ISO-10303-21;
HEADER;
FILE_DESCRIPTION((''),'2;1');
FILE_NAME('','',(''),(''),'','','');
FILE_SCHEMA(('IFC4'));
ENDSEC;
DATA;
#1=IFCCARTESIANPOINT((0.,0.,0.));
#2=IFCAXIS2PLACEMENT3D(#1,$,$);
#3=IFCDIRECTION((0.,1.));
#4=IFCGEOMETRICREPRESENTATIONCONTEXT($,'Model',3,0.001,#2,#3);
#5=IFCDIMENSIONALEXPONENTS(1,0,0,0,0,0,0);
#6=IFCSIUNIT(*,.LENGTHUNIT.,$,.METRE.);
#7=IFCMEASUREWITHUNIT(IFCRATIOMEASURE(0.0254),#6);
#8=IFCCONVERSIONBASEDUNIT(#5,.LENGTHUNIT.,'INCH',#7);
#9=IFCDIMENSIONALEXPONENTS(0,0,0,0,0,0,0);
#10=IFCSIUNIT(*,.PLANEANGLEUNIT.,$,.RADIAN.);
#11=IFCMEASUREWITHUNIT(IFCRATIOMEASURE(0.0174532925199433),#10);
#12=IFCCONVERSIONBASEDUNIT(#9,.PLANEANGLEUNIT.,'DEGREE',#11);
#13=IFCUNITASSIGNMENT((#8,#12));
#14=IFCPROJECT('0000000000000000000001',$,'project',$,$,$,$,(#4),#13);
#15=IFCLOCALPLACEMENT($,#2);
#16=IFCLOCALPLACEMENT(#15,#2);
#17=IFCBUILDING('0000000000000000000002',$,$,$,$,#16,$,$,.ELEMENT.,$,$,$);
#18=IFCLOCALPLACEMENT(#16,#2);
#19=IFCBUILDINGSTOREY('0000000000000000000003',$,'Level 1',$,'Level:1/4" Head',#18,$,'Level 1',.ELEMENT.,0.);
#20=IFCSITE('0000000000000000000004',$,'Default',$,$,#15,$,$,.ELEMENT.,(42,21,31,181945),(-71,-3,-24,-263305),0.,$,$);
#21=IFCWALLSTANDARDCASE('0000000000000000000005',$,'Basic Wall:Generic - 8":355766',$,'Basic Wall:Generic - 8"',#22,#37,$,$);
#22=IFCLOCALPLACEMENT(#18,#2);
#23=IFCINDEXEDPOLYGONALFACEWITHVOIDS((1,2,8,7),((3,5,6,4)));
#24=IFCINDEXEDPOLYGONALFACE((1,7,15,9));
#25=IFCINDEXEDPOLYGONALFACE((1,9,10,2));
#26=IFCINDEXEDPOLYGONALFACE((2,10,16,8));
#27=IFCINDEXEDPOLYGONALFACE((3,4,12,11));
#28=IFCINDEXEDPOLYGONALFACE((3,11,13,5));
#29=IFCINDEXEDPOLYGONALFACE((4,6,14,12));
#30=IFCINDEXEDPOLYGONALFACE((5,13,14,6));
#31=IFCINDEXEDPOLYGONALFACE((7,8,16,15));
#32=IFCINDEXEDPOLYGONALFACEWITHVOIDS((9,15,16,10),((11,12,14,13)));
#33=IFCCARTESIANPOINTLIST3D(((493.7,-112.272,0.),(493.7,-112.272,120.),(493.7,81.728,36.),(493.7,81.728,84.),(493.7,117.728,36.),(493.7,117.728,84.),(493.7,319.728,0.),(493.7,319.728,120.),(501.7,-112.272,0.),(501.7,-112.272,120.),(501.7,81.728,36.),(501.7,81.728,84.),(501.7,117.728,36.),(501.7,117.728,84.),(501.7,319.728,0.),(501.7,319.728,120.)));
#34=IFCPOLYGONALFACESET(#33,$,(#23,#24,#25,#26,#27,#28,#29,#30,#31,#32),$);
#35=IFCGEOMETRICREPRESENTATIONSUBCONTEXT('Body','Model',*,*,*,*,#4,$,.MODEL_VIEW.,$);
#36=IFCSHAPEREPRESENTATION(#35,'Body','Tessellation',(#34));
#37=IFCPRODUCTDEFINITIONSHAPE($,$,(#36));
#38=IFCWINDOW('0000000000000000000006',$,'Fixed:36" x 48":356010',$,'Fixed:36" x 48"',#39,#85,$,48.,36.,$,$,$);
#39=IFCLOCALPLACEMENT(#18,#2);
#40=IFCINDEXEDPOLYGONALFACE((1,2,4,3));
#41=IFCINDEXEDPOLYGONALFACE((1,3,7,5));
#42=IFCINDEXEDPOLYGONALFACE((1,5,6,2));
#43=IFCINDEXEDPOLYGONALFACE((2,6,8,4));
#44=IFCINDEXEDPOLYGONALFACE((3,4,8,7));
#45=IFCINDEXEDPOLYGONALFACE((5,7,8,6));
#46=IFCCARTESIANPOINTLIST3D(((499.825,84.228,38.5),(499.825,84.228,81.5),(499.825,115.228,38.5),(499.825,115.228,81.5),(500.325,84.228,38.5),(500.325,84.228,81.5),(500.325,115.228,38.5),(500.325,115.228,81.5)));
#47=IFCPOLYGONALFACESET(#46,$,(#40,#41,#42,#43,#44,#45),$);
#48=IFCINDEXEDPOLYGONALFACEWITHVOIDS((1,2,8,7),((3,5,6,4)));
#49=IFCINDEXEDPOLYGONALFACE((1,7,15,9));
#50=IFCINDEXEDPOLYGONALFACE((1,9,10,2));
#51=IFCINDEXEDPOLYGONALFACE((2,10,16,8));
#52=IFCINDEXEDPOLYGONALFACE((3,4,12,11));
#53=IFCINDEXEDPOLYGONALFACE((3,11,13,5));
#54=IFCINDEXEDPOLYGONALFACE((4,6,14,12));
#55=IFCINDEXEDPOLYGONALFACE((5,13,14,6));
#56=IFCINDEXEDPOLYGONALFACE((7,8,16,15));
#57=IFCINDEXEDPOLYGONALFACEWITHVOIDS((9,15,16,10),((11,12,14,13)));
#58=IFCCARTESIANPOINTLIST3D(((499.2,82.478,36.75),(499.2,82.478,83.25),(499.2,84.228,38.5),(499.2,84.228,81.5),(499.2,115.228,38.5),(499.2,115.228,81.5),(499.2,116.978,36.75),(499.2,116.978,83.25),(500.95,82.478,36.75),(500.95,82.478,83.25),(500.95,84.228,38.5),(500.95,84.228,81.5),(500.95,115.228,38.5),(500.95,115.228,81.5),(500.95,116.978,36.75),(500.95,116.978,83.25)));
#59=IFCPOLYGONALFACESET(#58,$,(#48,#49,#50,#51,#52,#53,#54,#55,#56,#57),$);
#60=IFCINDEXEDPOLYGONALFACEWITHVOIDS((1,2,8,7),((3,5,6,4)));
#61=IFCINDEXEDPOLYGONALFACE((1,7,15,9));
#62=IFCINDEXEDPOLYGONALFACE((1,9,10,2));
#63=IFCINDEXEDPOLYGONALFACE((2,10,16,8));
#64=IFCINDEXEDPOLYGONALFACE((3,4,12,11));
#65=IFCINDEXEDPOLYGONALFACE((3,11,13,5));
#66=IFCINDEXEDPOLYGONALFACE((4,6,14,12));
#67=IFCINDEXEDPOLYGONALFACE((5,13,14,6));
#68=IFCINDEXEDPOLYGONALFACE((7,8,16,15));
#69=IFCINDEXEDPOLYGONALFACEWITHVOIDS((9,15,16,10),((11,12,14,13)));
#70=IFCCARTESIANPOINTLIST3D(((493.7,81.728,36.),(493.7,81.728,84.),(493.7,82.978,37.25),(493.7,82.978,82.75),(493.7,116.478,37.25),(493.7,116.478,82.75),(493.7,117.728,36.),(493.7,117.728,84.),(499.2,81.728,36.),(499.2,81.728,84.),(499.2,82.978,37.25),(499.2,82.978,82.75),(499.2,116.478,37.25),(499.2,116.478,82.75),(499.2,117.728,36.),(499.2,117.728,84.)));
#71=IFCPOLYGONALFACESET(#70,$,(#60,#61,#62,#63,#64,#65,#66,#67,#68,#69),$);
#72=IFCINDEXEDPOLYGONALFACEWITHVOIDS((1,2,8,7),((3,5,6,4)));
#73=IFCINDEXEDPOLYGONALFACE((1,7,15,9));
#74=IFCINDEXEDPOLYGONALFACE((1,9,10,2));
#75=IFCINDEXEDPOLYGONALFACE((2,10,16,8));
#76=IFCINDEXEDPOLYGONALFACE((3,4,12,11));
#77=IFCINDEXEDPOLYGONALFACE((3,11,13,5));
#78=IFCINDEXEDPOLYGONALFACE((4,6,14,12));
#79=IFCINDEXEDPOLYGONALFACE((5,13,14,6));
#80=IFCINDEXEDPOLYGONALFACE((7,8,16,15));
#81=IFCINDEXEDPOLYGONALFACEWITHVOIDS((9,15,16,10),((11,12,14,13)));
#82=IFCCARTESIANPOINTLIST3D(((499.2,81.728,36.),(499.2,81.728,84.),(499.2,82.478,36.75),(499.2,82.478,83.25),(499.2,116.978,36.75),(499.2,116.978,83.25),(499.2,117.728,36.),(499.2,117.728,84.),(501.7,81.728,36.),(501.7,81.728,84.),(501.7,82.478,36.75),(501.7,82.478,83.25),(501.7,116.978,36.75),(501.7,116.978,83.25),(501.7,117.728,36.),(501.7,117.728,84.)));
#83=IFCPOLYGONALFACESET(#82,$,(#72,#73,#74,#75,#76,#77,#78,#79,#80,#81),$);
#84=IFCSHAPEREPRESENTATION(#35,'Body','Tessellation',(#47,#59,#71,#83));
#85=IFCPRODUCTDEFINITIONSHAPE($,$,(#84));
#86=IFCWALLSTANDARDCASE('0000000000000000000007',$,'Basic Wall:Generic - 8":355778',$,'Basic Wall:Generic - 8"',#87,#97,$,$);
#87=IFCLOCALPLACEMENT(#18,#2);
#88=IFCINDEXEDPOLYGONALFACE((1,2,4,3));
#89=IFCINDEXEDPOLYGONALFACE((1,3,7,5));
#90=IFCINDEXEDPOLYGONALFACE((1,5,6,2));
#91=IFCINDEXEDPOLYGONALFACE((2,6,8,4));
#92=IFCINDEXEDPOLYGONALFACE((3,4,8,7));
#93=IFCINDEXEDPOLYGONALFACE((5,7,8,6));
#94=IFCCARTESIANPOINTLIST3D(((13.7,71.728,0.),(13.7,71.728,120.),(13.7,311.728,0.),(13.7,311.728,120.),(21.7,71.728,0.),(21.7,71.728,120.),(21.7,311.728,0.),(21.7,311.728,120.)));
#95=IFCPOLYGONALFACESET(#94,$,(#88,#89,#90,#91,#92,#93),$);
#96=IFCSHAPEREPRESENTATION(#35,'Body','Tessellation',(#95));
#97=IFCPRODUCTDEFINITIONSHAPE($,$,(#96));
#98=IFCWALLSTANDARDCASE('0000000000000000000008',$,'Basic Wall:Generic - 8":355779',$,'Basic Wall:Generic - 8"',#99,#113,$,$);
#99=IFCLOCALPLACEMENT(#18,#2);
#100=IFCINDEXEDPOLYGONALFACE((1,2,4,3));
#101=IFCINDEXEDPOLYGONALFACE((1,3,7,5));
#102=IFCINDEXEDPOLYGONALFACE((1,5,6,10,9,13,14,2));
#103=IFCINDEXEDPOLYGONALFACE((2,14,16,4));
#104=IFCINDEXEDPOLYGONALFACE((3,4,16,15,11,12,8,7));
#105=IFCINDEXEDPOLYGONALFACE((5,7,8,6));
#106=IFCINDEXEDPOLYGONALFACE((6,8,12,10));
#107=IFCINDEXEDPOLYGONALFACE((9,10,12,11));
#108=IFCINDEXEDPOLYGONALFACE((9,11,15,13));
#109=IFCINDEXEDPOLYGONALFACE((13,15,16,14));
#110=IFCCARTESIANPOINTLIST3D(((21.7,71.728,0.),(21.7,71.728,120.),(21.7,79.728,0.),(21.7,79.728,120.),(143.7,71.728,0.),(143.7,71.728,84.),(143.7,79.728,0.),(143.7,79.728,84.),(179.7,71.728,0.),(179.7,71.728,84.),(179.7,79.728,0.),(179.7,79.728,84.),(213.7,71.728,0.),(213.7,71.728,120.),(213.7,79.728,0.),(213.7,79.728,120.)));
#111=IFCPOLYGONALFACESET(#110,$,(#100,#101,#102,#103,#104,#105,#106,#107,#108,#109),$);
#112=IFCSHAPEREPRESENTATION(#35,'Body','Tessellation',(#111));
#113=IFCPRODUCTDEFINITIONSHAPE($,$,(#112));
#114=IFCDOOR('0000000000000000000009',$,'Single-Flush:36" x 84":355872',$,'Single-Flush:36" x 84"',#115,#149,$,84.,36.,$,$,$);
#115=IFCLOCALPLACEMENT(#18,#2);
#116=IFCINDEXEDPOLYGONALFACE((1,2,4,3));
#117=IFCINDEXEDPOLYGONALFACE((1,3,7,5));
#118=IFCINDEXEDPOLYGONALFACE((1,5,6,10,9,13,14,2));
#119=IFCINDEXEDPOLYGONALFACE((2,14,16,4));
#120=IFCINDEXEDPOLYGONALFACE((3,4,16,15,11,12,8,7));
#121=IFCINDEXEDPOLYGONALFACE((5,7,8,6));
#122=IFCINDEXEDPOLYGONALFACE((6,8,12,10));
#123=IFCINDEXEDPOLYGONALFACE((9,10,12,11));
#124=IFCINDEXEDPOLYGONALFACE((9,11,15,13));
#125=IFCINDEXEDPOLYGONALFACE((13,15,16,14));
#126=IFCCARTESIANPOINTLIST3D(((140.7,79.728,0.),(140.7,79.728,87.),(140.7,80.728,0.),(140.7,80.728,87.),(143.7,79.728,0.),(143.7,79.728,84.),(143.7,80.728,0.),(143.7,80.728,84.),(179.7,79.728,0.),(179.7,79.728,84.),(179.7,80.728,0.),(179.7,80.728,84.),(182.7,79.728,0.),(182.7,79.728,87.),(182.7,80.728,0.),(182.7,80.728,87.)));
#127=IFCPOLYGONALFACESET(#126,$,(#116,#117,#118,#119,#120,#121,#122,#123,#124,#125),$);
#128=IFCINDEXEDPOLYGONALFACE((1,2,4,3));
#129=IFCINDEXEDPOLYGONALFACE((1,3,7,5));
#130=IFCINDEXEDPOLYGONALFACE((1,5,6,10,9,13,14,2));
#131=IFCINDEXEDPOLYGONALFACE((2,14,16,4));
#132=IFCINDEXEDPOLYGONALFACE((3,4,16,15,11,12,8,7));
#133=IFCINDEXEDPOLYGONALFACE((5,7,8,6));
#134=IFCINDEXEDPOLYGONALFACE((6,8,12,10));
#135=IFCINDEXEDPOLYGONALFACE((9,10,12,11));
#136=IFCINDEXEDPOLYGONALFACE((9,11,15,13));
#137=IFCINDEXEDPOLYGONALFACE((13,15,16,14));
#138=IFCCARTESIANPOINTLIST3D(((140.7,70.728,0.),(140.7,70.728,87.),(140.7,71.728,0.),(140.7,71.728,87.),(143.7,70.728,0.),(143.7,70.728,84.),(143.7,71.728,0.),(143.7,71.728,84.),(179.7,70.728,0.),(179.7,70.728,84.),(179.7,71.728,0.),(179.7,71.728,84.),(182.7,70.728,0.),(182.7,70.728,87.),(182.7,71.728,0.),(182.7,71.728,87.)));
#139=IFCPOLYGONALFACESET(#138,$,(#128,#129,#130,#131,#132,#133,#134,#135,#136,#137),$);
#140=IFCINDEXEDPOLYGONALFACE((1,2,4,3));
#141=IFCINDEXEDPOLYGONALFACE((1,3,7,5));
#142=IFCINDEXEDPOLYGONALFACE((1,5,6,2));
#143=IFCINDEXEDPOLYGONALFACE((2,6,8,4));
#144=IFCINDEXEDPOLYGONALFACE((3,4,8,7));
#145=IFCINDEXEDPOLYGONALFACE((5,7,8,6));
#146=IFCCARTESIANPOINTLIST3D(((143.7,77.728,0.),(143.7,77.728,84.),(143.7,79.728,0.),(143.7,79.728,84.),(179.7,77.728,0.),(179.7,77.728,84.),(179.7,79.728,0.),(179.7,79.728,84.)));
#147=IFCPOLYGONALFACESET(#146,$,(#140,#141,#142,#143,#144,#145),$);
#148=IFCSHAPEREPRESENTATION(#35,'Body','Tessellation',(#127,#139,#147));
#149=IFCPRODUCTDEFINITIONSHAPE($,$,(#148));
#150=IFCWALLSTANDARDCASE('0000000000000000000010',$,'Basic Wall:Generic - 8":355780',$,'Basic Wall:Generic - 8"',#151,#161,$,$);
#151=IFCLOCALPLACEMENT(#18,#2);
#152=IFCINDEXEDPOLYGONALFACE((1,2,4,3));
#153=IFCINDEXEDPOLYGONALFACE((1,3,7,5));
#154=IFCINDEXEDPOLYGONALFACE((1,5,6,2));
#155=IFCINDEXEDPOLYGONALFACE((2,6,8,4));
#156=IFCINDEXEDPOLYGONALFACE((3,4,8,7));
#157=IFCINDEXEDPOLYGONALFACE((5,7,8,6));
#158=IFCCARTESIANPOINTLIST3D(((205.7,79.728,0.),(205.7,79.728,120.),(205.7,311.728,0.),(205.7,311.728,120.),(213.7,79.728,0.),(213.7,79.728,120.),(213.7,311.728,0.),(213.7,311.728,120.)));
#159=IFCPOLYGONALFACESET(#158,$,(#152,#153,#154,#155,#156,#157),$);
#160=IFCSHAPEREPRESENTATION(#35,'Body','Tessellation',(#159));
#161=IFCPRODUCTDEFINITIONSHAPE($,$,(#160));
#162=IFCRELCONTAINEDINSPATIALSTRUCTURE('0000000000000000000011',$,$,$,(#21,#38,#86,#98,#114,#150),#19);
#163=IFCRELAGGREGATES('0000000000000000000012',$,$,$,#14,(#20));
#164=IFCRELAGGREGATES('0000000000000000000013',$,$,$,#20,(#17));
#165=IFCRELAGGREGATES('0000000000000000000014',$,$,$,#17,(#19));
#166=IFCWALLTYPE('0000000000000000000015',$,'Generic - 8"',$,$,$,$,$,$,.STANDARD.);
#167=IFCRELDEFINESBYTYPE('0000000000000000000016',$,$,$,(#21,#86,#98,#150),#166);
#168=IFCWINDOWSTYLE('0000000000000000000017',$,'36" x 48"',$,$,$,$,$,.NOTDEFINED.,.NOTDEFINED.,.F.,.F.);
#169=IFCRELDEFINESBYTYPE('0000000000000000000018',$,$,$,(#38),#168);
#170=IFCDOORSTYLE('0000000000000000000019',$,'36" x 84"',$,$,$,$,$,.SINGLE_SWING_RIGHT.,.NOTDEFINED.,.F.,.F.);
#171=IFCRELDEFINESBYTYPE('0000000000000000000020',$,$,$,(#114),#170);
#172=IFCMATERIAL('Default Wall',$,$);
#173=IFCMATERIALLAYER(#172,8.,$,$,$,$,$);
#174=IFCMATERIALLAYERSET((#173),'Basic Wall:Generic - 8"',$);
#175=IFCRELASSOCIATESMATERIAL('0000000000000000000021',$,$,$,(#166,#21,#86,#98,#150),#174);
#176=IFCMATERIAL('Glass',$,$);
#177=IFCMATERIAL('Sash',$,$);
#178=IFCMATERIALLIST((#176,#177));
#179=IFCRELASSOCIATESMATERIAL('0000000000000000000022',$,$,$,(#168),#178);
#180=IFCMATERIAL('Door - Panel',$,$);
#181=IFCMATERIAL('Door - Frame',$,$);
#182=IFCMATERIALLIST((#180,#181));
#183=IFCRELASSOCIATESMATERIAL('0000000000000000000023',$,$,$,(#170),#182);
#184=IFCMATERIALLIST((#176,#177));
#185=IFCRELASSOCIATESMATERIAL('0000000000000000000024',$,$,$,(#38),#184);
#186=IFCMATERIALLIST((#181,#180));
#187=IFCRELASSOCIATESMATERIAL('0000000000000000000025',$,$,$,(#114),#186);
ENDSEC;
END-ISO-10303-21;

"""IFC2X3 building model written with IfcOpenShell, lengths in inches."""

from ifc_helpers import new_model, entity, si_unit, converted_unit, direction, frame, frame_2d, origin, place, context, subcontext, project, spatial, polyline, rectangle, outline, extrude, clip, halfspace, source, transform, mapped, material, material_list, layer, layer_set, layer_usage, type_object, type_shapes, element, fill, save


model = new_model("IFC2X3")

# Units and contexts
model_context = context("Model", 3, precision=0.001, world=origin(), true_north=direction((0.0, 1.0)))
body_context = subcontext(model_context, "Body", "Model", "MODEL_VIEW")
ifc_project = project(units=[converted_unit("LENGTHUNIT", "INCH", entity("IfcRatioMeasure", 0.0254), si_unit("LENGTHUNIT", "METRE"), dimensions=[1, 0, 0, 0, 0, 0, 0]), converted_unit("PLANEANGLEUNIT", "DEGREE", entity("IfcRatioMeasure", 0.0174532925199433), si_unit("PLANEANGLEUNIT", "RADIAN"), dimensions=[0, 0, 0, 0, 0, 0, 0])], contexts=[model_context])

# Site, building, storey
site_placement = place(None, origin())
site = spatial("IfcSite", under=ifc_project, at=site_placement, Name="Default", CompositionType="ELEMENT", RefLatitude=(42, 21, 31, 181945), RefLongitude=(-71, -3, -24, -263305), RefElevation=0.0)
building_placement = place(site_placement, origin())
building = spatial("IfcBuilding", under=site, at=building_placement, CompositionType="ELEMENT")
storey_placement = place(building_placement, origin())
storey = spatial("IfcBuildingStorey", under=building, at=storey_placement, Name="Level 1", ObjectType="Level:1/4\" Head", LongName="Level 1", CompositionType="ELEMENT", Elevation=0.0)

# Shared definitions
ifc_material_1 = material(Name="Default Wall")
ifc_layer = layer(ifc_material_1, 8.0)
ifc_layer_set = layer_set([ifc_layer], Name="Basic Wall:Generic - 8\"")
wall_type = type_object("IfcWallType", Name="Generic - 8\"", PredefinedType="STANDARD", material=ifc_layer_set)
ifc_material_2 = material(Name="Glass")
ifc_material_3 = material(Name="Sash")
ifc_material_list_1 = material_list([ifc_material_2, ifc_material_3])
window_style = type_object("IfcWindowStyle", Name="36\" x 48\"", ConstructionType="NOTDEFINED", OperationType="NOTDEFINED", ParameterTakesPrecedence=False, Sizeable=False, material=ifc_material_list_1)
shared_shape_1 = source(origin(), body_context, "Body", "SweptSolid", [
    extrude(rectangle(XDim=0.5, YDim=31.0, at=frame_2d((0.0, 0.0), x_axis=(1.0, 0.0))), frame((18.0, 6.375, 2.5), z_axis=(0.0, 0.0, 1.0), x_axis=(0.0, 1.0, 0.0)), (0.0, 0.0, 1.0), 43.0),
    extrude(outline(polyline([(-17.25, -23.25), (17.25, -23.25), (17.25, 23.25), (-17.25, 23.25), (-17.25, -23.25)]), holes=[polyline([(-15.5, -21.5), (-15.5, 21.5), (15.5, 21.5), (15.5, -21.5), (-15.5, -21.5)])]), frame((18.0, 5.5, 24.0), z_axis=(0.0, 1.0, 0.0), x_axis=(1.0, 0.0, 0.0)), (0.0, 0.0, 1.0), 1.75),
    extrude(outline(polyline([(-18.0, -24.0), (18.0, -24.0), (18.0, 24.0), (-18.0, 24.0), (-18.0, -24.0)]), holes=[polyline([(-16.75, -22.75), (-16.75, 22.75), (16.75, 22.75), (16.75, -22.75), (-16.75, -22.75)])]), frame((18.0, 0.0, 24.0), z_axis=(0.0, 1.0, 0.0), x_axis=(1.0, 0.0, 0.0)), (0.0, 0.0, 1.0), 5.5),
    extrude(outline(polyline([(-24.0, -18.0), (24.0, -18.0), (24.0, 18.0), (-24.0, 18.0), (-24.0, -18.0)]), holes=[polyline([(-23.25, -17.25), (-23.25, 17.25), (23.25, 17.25), (23.25, -17.25), (-23.25, -17.25)])]), frame((18.0, 5.5, 24.0), z_axis=(0.0, 1.0, 0.0), x_axis=(0.0, 0.0, -1.0)), (0.0, 0.0, 1.0), 2.5),
])
type_shapes(window_style, [shared_shape_1])

# Shared definitions
ifc_material_4 = material(Name="Door - Frame")
ifc_material_5 = material(Name="Door - Panel")
ifc_material_list_2 = material_list([ifc_material_5, ifc_material_4])
door_style = type_object("IfcDoorStyle", Name="36\" x 84\"", ConstructionType="NOTDEFINED", OperationType="SINGLE_SWING_RIGHT", ParameterTakesPrecedence=False, Sizeable=False, material=ifc_material_list_2)
shared_shape_2 = source(origin(), body_context, "Body", "SweptSolid", [
    extrude(outline(polyline([(-21.0, -44.25), (21.0, -44.25), (21.0, 42.75), (18.0, 42.75), (18.0, -41.25), (-18.0, -41.25), (-18.0, 42.75), (-21.0, 42.75), (-21.0, -44.25)])), frame((18.0, 8.0, 42.75), z_axis=(0.0, 1.0, 0.0), x_axis=(1.0, 0.0, 0.0)), (0.0, 0.0, 1.0), 1.0),
    extrude(outline(polyline([(-44.25, -21.0), (42.75, -21.0), (42.75, -18.0), (-41.25, -18.0), (-41.25, 18.0), (42.75, 18.0), (42.75, 21.0), (-44.25, 21.0), (-44.25, -21.0)])), frame((18.0, -1.0, 42.75), z_axis=(0.0, 1.0, 0.0), x_axis=(0.0, 0.0, -1.0)), (0.0, 0.0, 1.0), 1.0),
    extrude(rectangle(XDim=2.0, YDim=36.0, at=frame_2d((0.0, 0.0), x_axis=(1.0, 0.0))), frame((18.0, 7.0, 0.0), z_axis=(0.0, 0.0, 1.0), x_axis=(0.0, 1.0, 0.0)), (0.0, 0.0, 1.0), 84.0),
])
type_shapes(door_style, [shared_shape_2])

# Wall, opening, window
ifc_layer_usage_1 = layer_usage(ifc_layer_set, "AXIS2", "NEGATIVE", 4.0)
wall_1_placement = place(storey_placement, frame((497.7, 319.728, 0.0), z_axis=(0.0, 0.0, 1.0), x_axis=(0.0, -1.0, 0.0)))
wall_1 = element("IfcWallStandardCase", 1, at=wall_1_placement, inside=storey, type_object=wall_type, material=ifc_layer_usage_1, Name="Basic Wall:Generic - 8\":355766", ObjectType="Basic Wall:Generic - 8\"", context=body_context, shape_type="Clipping", body=[
    clip(extrude(rectangle(XDim=432.0, YDim=8.0, at=frame_2d((216.0, 0.0), x_axis=(-1.0, 0.0))), origin(), (0.0, 0.0, 1.0), 120.0), halfspace(origin(), True)),
])
opening_1_placement = place(wall_1_placement, frame((202.0, -4.0, 36.0)))
opening_1 = element("IfcOpeningElement", 2, at=opening_1_placement, cuts=wall_1, ObjectType="Opening", context=body_context, shape_type="SweptSolid", body=[
    extrude(rectangle(XDim=48.0, YDim=36.0, at=frame_2d((24.0, 18.0), x_axis=(-1.0, 0.0))), frame((0.0, 0.0, 0.0), z_axis=(0.0, 1.0, 0.0), x_axis=(0.0, 0.0, 1.0)), (0.0, 0.0, 1.0), 8.0),
])
ifc_material_list_3 = material_list([ifc_material_2, ifc_material_3])
window_1_placement = place(opening_1_placement, origin())
window_1 = element("IfcWindow", 3, at=window_1_placement, inside=storey, type_object=window_style, material=ifc_material_list_3, Name="Fixed:36\" x 48\":356010", ObjectType="Fixed:36\" x 48\"", OverallHeight=48.0, OverallWidth=36.0, context=body_context, shape_type="MappedRepresentation", body=[
    mapped(shared_shape_1, transform((0.0, 0.0, 0.0), scale=1.0)),
])
fill(opening_1, window_1)

# Wall
ifc_layer_usage_2 = layer_usage(ifc_layer_set, "AXIS2", "NEGATIVE", 4.0)
wall_2_placement = place(storey_placement, frame((17.7, 71.728, 0.0), z_axis=(0.0, 0.0, 1.0), x_axis=(0.0, 1.0, 0.0)))
element("IfcWallStandardCase", 4, at=wall_2_placement, inside=storey, type_object=wall_type, material=ifc_layer_usage_2, Name="Basic Wall:Generic - 8\":355778", ObjectType="Basic Wall:Generic - 8\"", context=body_context, shape_type="Clipping", body=[
    clip(extrude(rectangle(XDim=240.0, YDim=8.0, at=frame_2d((120.0, 0.0), x_axis=(-1.0, 0.0))), origin(), (0.0, 0.0, 1.0), 120.0), halfspace(origin(), True)),
])

# Wall, opening, door
ifc_layer_usage_3 = layer_usage(ifc_layer_set, "AXIS2", "NEGATIVE", 4.0)
wall_3_placement = place(storey_placement, frame((213.7, 75.728, 0.0), z_axis=(0.0, 0.0, 1.0), x_axis=(-1.0, 0.0, 0.0)))
wall_3 = element("IfcWallStandardCase", 5, at=wall_3_placement, inside=storey, type_object=wall_type, material=ifc_layer_usage_3, Name="Basic Wall:Generic - 8\":355779", ObjectType="Basic Wall:Generic - 8\"", context=body_context, shape_type="Clipping", body=[
    clip(extrude(rectangle(XDim=192.0, YDim=8.0, at=frame_2d((96.0, 0.0), x_axis=(-1.0, 0.0))), origin(), (0.0, 0.0, 1.0), 120.0), halfspace(origin(), True)),
])
opening_2_placement = place(wall_3_placement, frame((70.0, 4.0, 0.0)))
opening_2 = element("IfcOpeningElement", 6, at=opening_2_placement, cuts=wall_3, ObjectType="Opening", context=body_context, shape_type="SweptSolid", body=[
    extrude(rectangle(XDim=36.0, YDim=84.0, at=frame_2d((42.0, 18.0), x_axis=(0.0, 1.0))), frame((0.0, 0.0, 0.0), z_axis=(0.0, -1.0, 0.0), x_axis=(0.0, 0.0, 1.0)), (0.0, 0.0, 1.0), 8.0),
])
ifc_material_list_4 = material_list([ifc_material_4, ifc_material_5])
door_1_placement = place(opening_2_placement, frame((0.0, 0.0, 0.0), z_axis=(0.0, 0.0, 1.0), x_axis=(-1.0, 0.0, 0.0)))
door_1 = element("IfcDoor", 7, at=door_1_placement, inside=storey, type_object=door_style, material=ifc_material_list_4, Name="Single-Flush:36\" x 84\":355872", ObjectType="Single-Flush:36\" x 84\"", OverallHeight=84.0, OverallWidth=36.0, context=body_context, shape_type="MappedRepresentation", body=[
    mapped(shared_shape_2, transform((0.0, 0.0, 0.0), scale=1.0)),
])
fill(opening_2, door_1)

# Wall
ifc_layer_usage_4 = layer_usage(ifc_layer_set, "AXIS2", "NEGATIVE", 4.0)
wall_4_placement = place(storey_placement, frame((209.7, 311.728, 0.0), z_axis=(0.0, 0.0, 1.0), x_axis=(0.0, -1.0, 0.0)))
element("IfcWallStandardCase", 8, at=wall_4_placement, inside=storey, type_object=wall_type, material=ifc_layer_usage_4, Name="Basic Wall:Generic - 8\":355780", ObjectType="Basic Wall:Generic - 8\"", context=body_context, shape_type="Clipping", body=[
    clip(extrude(rectangle(XDim=232.0, YDim=8.0, at=frame_2d((116.0, 0.0), x_axis=(-1.0, 0.0))), origin(), (0.0, 0.0, 1.0), 120.0), halfspace(origin(), True)),
])

save(model, "model.ifc")
